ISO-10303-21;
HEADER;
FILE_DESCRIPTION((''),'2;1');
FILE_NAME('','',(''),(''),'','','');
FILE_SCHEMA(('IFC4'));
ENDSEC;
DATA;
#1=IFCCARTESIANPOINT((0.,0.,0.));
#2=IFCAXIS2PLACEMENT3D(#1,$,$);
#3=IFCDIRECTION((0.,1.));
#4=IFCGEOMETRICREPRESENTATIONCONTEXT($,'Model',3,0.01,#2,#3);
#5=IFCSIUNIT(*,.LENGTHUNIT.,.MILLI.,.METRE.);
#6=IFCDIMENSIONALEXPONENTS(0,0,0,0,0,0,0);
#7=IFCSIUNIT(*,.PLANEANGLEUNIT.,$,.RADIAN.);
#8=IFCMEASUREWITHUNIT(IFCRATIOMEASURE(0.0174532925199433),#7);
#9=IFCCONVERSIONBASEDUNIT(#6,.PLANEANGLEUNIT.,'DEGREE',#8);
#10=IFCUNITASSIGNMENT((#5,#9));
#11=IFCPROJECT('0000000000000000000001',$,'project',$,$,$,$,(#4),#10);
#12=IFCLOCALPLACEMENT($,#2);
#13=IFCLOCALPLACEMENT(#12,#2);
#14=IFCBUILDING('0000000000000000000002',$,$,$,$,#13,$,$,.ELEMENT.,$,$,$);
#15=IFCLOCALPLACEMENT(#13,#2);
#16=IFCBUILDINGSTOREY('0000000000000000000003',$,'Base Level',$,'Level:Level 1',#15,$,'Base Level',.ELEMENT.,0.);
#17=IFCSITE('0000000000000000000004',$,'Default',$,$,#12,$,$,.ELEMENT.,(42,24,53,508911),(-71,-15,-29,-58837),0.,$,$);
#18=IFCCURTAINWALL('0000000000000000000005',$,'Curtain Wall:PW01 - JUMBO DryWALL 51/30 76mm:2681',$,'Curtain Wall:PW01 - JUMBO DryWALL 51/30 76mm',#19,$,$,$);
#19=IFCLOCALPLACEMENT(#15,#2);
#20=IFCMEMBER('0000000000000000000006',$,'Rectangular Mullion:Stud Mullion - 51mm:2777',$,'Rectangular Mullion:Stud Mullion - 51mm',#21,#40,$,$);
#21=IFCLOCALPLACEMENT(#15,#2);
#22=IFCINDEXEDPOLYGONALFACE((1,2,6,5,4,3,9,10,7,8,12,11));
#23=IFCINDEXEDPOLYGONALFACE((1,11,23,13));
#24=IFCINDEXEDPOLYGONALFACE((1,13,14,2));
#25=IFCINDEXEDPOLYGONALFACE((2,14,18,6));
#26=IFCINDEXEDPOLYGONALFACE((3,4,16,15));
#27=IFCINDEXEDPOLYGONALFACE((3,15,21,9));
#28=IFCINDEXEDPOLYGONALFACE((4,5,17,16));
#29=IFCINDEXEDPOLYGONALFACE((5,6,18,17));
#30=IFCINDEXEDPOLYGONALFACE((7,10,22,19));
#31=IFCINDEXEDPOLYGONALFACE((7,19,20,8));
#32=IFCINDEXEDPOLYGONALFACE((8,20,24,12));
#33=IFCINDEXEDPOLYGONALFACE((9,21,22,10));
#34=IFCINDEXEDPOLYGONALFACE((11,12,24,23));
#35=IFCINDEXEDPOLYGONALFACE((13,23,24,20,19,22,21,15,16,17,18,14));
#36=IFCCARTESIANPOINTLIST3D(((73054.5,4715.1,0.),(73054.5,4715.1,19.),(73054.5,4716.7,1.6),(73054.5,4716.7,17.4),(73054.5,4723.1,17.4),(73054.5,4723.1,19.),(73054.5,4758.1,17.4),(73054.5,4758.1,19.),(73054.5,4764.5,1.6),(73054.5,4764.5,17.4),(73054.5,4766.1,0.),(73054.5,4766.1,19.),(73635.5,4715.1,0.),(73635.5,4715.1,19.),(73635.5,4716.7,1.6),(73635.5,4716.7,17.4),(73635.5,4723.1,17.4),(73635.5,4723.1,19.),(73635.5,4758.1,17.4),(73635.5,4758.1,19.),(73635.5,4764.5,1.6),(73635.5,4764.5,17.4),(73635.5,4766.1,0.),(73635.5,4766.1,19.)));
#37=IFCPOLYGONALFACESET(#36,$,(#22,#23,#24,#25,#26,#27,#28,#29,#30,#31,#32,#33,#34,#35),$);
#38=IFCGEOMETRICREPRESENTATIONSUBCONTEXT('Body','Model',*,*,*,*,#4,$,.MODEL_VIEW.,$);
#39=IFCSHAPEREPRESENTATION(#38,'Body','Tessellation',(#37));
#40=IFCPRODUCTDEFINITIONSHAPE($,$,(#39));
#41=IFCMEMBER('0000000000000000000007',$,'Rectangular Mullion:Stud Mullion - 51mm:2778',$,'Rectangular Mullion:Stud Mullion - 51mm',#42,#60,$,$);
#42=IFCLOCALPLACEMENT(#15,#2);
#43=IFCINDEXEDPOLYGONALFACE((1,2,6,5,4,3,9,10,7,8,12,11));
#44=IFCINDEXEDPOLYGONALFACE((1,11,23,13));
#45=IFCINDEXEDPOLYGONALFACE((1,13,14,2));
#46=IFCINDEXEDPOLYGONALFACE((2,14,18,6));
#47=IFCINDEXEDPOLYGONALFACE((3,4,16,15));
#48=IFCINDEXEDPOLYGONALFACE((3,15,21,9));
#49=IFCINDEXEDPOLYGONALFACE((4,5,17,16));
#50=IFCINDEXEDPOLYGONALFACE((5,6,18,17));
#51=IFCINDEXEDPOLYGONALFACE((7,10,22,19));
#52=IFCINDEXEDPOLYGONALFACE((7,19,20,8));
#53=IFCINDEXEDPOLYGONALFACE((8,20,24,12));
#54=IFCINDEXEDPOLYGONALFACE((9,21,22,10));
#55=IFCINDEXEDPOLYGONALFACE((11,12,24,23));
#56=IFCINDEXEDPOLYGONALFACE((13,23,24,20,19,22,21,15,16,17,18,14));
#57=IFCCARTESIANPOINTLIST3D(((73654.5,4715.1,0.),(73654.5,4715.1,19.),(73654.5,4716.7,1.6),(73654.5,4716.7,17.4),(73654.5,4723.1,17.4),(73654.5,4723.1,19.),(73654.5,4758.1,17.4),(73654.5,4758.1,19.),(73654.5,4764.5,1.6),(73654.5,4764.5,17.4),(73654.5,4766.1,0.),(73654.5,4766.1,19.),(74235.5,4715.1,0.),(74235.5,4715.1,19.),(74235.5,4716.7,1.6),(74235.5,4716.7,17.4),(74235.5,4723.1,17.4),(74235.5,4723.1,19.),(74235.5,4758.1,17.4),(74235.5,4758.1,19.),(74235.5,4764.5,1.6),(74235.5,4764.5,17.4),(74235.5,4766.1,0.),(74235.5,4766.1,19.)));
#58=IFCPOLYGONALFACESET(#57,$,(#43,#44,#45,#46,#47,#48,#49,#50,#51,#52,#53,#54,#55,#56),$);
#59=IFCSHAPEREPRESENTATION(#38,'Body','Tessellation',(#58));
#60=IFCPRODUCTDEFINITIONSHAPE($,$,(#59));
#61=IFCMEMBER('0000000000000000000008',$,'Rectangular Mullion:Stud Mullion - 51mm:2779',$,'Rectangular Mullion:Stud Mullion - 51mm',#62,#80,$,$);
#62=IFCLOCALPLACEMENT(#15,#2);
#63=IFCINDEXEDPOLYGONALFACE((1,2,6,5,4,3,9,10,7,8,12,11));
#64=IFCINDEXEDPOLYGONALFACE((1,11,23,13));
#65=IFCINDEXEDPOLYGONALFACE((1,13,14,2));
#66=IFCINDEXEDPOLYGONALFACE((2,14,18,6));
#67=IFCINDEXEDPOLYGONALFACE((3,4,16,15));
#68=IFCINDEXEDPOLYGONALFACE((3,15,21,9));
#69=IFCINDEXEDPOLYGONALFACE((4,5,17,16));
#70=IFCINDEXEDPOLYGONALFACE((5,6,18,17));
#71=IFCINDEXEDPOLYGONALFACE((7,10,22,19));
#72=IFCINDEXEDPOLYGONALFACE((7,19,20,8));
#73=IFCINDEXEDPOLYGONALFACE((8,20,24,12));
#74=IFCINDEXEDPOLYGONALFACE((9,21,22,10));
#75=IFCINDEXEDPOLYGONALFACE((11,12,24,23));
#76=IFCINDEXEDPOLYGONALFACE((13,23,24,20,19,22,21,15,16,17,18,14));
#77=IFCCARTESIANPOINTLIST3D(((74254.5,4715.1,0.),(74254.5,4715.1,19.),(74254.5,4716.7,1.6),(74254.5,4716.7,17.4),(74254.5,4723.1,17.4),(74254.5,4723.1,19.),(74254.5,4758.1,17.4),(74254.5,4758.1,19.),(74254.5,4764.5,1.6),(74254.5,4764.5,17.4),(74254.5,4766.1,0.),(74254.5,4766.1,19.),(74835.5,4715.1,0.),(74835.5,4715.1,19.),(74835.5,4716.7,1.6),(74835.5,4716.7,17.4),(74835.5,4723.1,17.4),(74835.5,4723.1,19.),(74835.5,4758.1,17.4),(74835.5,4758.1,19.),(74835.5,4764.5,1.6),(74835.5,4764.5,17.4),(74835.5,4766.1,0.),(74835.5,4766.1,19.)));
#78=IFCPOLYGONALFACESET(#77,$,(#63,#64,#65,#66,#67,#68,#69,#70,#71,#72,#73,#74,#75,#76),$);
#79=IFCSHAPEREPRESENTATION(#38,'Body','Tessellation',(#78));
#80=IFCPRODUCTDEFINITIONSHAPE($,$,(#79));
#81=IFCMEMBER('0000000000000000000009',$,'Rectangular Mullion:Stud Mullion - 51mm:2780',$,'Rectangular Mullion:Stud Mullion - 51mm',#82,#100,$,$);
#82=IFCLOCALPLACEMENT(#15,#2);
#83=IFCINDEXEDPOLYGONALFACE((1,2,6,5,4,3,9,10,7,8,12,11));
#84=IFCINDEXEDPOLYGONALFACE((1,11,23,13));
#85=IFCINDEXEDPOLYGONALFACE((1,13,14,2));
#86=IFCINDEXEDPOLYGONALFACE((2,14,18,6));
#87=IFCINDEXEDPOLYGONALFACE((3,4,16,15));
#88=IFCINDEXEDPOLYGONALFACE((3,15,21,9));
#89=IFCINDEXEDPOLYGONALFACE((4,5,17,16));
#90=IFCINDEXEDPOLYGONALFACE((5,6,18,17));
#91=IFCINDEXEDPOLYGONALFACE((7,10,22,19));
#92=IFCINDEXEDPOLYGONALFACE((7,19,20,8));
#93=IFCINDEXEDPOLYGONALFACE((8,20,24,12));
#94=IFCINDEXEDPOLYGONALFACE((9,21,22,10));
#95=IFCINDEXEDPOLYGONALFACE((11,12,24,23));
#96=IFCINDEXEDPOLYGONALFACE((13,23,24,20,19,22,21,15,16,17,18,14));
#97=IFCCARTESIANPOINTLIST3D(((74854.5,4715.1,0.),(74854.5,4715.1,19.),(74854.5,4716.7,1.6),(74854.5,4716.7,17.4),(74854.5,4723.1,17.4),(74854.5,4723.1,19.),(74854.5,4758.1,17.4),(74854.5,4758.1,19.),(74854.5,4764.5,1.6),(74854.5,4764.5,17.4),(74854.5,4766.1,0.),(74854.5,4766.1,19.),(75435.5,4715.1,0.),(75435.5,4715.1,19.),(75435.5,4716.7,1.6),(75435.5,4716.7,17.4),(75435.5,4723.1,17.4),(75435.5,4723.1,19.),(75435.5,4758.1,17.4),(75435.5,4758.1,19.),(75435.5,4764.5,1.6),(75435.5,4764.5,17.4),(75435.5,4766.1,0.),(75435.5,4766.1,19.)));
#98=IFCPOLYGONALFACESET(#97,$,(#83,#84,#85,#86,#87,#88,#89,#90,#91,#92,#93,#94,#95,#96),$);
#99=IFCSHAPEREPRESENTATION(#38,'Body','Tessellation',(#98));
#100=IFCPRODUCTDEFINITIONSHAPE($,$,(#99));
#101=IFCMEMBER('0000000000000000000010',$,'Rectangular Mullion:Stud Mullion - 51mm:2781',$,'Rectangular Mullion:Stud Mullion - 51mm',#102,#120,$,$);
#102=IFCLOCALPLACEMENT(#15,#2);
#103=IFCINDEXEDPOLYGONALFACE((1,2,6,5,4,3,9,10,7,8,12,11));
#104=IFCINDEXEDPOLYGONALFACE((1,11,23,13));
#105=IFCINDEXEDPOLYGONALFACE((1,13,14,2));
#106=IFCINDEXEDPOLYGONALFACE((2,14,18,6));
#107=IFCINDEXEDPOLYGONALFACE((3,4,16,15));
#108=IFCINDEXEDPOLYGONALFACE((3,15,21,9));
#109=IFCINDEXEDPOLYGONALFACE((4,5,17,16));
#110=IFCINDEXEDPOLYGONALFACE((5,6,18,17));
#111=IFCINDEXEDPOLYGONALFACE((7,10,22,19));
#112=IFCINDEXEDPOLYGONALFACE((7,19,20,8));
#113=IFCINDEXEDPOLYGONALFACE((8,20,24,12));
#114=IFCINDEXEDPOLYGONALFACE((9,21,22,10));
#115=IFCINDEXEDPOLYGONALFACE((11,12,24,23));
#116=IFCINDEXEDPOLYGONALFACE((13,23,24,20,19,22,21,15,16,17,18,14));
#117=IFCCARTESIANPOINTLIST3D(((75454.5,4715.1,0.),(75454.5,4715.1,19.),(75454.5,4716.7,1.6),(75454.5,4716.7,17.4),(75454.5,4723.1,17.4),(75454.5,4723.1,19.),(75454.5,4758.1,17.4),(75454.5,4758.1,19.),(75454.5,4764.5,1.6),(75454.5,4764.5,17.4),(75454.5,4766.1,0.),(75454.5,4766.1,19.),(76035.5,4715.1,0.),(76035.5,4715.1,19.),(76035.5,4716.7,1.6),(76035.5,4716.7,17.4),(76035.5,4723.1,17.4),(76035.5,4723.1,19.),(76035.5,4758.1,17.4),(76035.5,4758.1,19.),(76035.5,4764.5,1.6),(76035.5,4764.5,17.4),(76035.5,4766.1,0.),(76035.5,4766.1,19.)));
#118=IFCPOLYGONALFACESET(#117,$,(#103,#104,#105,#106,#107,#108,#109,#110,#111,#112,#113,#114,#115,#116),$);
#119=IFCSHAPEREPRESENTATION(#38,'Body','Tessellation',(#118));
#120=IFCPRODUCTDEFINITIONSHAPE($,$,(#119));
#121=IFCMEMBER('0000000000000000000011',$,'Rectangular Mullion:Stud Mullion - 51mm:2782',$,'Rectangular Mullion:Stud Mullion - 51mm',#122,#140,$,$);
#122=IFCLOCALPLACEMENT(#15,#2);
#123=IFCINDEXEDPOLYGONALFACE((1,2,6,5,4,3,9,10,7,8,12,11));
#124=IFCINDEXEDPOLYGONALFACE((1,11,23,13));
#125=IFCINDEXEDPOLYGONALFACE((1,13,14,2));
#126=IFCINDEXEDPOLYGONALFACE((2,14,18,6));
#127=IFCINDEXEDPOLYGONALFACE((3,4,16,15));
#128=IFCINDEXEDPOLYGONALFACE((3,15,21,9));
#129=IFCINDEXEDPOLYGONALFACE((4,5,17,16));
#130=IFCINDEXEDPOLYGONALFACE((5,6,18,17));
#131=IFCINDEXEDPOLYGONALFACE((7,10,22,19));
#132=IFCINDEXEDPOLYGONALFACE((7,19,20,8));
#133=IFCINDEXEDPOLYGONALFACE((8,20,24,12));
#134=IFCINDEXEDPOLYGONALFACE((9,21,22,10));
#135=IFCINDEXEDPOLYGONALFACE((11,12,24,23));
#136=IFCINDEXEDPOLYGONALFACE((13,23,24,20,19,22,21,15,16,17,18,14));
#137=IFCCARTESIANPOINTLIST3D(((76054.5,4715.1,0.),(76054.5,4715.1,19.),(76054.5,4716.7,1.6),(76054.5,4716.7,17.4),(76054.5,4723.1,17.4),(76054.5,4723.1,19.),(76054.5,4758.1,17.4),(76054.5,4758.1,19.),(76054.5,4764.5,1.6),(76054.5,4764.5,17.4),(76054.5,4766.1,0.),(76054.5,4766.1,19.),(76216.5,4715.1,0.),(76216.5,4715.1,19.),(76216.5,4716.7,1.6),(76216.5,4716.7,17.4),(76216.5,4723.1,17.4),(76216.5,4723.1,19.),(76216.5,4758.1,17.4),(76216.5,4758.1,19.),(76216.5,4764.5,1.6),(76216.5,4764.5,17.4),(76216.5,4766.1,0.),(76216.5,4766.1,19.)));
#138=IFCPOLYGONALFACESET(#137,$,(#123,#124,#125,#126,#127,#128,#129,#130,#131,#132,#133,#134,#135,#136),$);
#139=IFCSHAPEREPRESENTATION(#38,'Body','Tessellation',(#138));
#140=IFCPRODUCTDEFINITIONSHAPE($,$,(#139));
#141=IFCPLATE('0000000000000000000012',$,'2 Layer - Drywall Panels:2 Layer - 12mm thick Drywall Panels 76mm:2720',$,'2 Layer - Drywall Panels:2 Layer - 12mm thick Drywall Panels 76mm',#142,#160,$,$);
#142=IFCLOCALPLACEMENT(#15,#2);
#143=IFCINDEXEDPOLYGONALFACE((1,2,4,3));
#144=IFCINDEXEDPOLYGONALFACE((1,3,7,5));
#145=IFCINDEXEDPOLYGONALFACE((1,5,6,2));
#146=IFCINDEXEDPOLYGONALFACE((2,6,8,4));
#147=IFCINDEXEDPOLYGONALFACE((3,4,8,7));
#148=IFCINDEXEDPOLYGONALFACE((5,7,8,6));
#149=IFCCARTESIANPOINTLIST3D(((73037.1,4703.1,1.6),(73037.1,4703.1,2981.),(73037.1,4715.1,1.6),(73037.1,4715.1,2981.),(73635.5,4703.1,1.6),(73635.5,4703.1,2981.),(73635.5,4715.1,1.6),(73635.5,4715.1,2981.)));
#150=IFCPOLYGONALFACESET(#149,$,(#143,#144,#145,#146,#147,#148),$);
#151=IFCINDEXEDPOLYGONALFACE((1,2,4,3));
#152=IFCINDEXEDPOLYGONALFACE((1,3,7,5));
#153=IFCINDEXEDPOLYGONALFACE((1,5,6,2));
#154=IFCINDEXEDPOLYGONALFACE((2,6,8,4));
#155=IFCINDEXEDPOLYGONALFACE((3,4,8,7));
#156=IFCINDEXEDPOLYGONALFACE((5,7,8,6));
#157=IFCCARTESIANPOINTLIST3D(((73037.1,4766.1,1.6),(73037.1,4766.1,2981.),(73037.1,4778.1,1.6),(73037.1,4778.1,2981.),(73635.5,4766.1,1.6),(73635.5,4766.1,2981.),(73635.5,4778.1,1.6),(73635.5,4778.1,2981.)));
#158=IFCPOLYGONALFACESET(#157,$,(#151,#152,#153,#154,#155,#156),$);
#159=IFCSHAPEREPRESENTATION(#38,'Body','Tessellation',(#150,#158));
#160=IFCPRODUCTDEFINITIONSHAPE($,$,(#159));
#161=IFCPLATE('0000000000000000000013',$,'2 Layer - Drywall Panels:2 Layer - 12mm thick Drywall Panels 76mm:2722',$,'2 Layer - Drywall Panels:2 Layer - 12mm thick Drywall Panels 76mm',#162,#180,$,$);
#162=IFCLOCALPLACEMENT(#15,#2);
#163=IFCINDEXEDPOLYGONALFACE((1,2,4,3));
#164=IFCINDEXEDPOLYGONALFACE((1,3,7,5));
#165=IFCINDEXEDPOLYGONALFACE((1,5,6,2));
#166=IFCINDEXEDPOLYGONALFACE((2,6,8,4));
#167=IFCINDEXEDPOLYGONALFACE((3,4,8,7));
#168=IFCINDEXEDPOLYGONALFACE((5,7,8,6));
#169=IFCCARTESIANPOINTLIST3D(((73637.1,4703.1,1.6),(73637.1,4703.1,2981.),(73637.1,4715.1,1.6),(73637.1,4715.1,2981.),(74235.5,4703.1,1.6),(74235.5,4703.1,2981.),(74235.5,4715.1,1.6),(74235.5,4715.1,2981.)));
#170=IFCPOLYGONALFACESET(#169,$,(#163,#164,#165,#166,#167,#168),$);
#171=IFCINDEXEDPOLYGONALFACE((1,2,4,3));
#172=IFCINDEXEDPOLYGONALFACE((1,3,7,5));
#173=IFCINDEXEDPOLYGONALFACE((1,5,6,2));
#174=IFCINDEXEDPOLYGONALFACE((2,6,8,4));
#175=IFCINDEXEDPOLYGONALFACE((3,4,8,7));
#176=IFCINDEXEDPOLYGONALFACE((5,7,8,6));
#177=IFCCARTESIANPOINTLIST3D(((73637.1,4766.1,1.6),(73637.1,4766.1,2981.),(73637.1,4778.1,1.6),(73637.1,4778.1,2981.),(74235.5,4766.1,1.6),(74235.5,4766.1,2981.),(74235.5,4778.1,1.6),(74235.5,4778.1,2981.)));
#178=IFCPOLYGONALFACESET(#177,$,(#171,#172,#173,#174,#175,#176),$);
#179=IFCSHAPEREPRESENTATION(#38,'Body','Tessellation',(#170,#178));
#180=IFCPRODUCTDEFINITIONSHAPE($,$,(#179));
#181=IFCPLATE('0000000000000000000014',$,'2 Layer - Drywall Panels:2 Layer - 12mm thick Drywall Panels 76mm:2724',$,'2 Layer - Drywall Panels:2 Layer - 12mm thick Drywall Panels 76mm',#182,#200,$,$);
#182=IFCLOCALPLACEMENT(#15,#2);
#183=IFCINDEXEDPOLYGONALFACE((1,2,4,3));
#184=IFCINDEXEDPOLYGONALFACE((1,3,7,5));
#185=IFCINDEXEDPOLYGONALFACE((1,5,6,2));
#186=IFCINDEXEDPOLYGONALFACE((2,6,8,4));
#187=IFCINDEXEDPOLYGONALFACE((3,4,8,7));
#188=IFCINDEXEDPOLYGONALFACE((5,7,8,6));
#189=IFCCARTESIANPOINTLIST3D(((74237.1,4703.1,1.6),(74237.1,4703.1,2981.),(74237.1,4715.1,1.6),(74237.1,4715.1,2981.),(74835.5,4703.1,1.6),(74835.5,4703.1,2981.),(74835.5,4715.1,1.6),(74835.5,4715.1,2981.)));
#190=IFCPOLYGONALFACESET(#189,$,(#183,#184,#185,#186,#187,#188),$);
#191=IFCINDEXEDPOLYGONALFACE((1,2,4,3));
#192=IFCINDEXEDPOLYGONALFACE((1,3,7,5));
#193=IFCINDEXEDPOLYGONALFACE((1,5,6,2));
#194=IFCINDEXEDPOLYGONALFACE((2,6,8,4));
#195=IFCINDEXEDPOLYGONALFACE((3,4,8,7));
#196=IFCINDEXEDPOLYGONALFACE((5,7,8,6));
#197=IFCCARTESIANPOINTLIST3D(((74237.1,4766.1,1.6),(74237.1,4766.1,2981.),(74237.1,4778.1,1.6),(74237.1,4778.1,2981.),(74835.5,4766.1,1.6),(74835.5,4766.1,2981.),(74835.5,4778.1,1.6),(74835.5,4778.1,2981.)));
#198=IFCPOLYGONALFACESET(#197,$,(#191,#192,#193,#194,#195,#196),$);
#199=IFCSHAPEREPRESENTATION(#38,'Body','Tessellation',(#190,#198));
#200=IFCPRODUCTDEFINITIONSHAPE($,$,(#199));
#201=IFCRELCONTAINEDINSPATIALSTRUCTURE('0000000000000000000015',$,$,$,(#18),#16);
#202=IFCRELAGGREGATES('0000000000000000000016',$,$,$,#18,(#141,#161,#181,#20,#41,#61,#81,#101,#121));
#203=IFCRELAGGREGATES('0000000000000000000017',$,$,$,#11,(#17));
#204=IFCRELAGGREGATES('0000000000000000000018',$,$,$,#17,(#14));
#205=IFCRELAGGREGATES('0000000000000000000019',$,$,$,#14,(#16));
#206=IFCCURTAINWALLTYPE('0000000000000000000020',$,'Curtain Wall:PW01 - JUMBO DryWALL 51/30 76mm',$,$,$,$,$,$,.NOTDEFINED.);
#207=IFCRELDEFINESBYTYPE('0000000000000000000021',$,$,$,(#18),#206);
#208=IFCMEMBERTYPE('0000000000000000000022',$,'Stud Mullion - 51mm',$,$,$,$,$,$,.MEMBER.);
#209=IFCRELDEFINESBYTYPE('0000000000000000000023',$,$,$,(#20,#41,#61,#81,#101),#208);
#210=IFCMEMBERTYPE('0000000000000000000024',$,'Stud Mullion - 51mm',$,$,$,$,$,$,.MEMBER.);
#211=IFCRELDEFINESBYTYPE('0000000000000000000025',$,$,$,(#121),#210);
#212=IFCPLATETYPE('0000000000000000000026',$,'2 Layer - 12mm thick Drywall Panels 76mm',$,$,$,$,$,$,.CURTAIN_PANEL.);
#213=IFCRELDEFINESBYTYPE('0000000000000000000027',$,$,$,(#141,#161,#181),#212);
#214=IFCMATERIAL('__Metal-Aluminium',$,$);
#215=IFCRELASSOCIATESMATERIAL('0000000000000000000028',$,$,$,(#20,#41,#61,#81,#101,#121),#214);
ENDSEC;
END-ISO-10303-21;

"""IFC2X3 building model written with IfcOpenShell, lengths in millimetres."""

from ifc_helpers import new_model, entity, si_unit, converted_unit, direction, frame, frame_2d, origin, origin_2d_with_axis, place, context, subcontext, project, spatial, polyline, rectangle, outline, extrude, source, transform, mapped, material, type_object, type_shapes, element, aggregate, save


model = new_model("IFC2X3")

# Units and contexts
model_context = context("Model", 3, precision=0.01, world=origin(), true_north=direction((0.0, 1.0)))
body_context = subcontext(model_context, "Body", "Model", "MODEL_VIEW")
ifc_project = project(units=[si_unit("LENGTHUNIT", "METRE", prefix="MILLI"), converted_unit("PLANEANGLEUNIT", "DEGREE", entity("IfcRatioMeasure", 0.0174532925199433), si_unit("PLANEANGLEUNIT", "RADIAN"), dimensions=[0, 0, 0, 0, 0, 0, 0])], contexts=[model_context])

# Site, building, storey
site_placement = place(None, origin())
site = spatial("IfcSite", under=ifc_project, at=site_placement, Name="Default", CompositionType="ELEMENT", RefLatitude=(42, 24, 53, 508911), RefLongitude=(-71, -15, -29, -58837), RefElevation=0.0)
building_placement = place(site_placement, origin())
building = spatial("IfcBuilding", under=site, at=building_placement, CompositionType="ELEMENT")
storey_placement = place(building_placement, origin())
storey = spatial("IfcBuildingStorey", under=building, at=storey_placement, Name="Base Level", ObjectType="Level:Level 1", LongName="Base Level", CompositionType="ELEMENT", Elevation=0.0)

# Curtain wall, members, plates
curtain_wall_type = type_object("IfcCurtainWallType", Name="Curtain Wall:PW01 - JUMBO DryWALL 51/30 76mm", PredefinedType="NOTDEFINED")
curtain_wall_placement = place(building_placement, origin())
curtain_wall = element("IfcCurtainWall", 1, at=curtain_wall_placement, inside=storey, type_object=curtain_wall_type, Name="Curtain Wall:PW01 - JUMBO DryWALL 51/30 76mm:2681", ObjectType="Curtain Wall:PW01 - JUMBO DryWALL 51/30 76mm")
ifc_material = material(Name="__Metal-Aluminium")
member_type_1 = type_object("IfcMemberType", Name="Stud Mullion - 51mm", PredefinedType="MEMBER")
shared_shape_1 = source(origin(), body_context, "Body", "SweptSolid", [
    extrude(outline(polyline([(17.5, -6.6), (25.5, -6.6), (25.5, 12.4), (-25.5, 12.4), (-25.5, -6.6), (-17.5, -6.6), (-17.5, -5.0), (-23.9, -5.0), (-23.9, 10.8), (23.9, 10.8), (23.9, -5.0), (17.5, -5.0), (17.5, -6.6)])), frame((-12.4, 0.0, -581.0), z_axis=(0.0, 0.0, 1.0), x_axis=(0.0, -1.0, 0.0)), (0.0, 0.0, 1.0), 581.0),
])
type_shapes(member_type_1, [shared_shape_1])
member_1_placement = place(building_placement, frame((73054.5, 4740.6, 0.0), z_axis=(-1.0, 0.0, 0.0), x_axis=(0.0, 0.0, -1.0)))
member_1 = element("IfcMember", 2, at=member_1_placement, type_object=member_type_1, material=ifc_material, Name="Rectangular Mullion:Stud Mullion - 51mm:2777", ObjectType="Rectangular Mullion:Stud Mullion - 51mm", context=body_context, shape_type="MappedRepresentation", body=[
    mapped(shared_shape_1, transform((0.0, 0.0, 0.0), scale=1.0)),
])
member_2_placement = place(building_placement, frame((73654.5, 4740.6, 0.0), z_axis=(-1.0, 0.0, 0.0), x_axis=(0.0, 0.0, -1.0)))
member_2 = element("IfcMember", 3, at=member_2_placement, type_object=member_type_1, material=ifc_material, Name="Rectangular Mullion:Stud Mullion - 51mm:2778", ObjectType="Rectangular Mullion:Stud Mullion - 51mm", context=body_context, shape_type="MappedRepresentation", body=[
    mapped(shared_shape_1, transform((0.0, 0.0, 0.0), scale=1.0)),
])
member_3_placement = place(building_placement, frame((74254.5, 4740.6, 0.0), z_axis=(-1.0, 0.0, 0.0), x_axis=(0.0, 0.0, -1.0)))
member_3 = element("IfcMember", 4, at=member_3_placement, type_object=member_type_1, material=ifc_material, Name="Rectangular Mullion:Stud Mullion - 51mm:2779", ObjectType="Rectangular Mullion:Stud Mullion - 51mm", context=body_context, shape_type="MappedRepresentation", body=[
    mapped(shared_shape_1, transform((0.0, 0.0, 0.0), scale=1.0)),
])
member_4_placement = place(building_placement, frame((74854.5, 4740.6, 0.0), z_axis=(-1.0, 0.0, 0.0), x_axis=(0.0, 0.0, -1.0)))
member_4 = element("IfcMember", 5, at=member_4_placement, type_object=member_type_1, material=ifc_material, Name="Rectangular Mullion:Stud Mullion - 51mm:2780", ObjectType="Rectangular Mullion:Stud Mullion - 51mm", context=body_context, shape_type="MappedRepresentation", body=[
    mapped(shared_shape_1, transform((0.0, 0.0, 0.0), scale=1.0)),
])
member_5_placement = place(building_placement, frame((75454.5, 4740.6, 0.0), z_axis=(-1.0, 0.0, 0.0), x_axis=(0.0, 0.0, -1.0)))
member_5 = element("IfcMember", 6, at=member_5_placement, type_object=member_type_1, material=ifc_material, Name="Rectangular Mullion:Stud Mullion - 51mm:2781", ObjectType="Rectangular Mullion:Stud Mullion - 51mm", context=body_context, shape_type="MappedRepresentation", body=[
    mapped(shared_shape_1, transform((0.0, 0.0, 0.0), scale=1.0)),
])
member_type_2 = type_object("IfcMemberType", Name="Stud Mullion - 51mm", PredefinedType="MEMBER")
shared_shape_2 = source(origin(), body_context, "Body", "SweptSolid", [
    extrude(outline(polyline([(17.5, -6.6), (25.5, -6.6), (25.5, 12.4), (-25.5, 12.4), (-25.5, -6.6), (-17.5, -6.6), (-17.5, -5.0), (-23.9, -5.0), (-23.9, 10.8), (23.9, 10.8), (23.9, -5.0), (17.5, -5.0), (17.5, -6.6)])), frame((-12.4, 0.0, -162.0), z_axis=(0.0, 0.0, 1.0), x_axis=(0.0, -1.0, 0.0)), (0.0, 0.0, 1.0), 162.0),
])
type_shapes(member_type_2, [shared_shape_2])
member_6_placement = place(building_placement, frame((76054.5, 4740.6, 0.0), z_axis=(-1.0, 0.0, 0.0), x_axis=(0.0, 0.0, -1.0)))
member_6 = element("IfcMember", 7, at=member_6_placement, type_object=member_type_2, material=ifc_material, Name="Rectangular Mullion:Stud Mullion - 51mm:2782", ObjectType="Rectangular Mullion:Stud Mullion - 51mm", context=body_context, shape_type="MappedRepresentation", body=[
    mapped(shared_shape_2, transform((0.0, 0.0, 0.0), scale=1.0)),
])
plate_type_1 = type_object("IfcPlateType", Name="2 Layer - 12mm thick Drywall Panels 76mm", PredefinedType="CURTAIN_PANEL")
shared_shape_3 = source(origin(), body_context, "Body", "SweptSolid", [
    extrude(rectangle(XDim=598.4, YDim=12.0, at=origin_2d_with_axis()), frame((0.0, -31.5, 0.0), z_axis=(0.0, 0.0, 1.0), x_axis=(-1.0, 0.0, 0.0)), (0.0, 0.0, 1.0), 2979.4),
    extrude(rectangle(XDim=12.0, YDim=598.4, at=frame_2d((0.0, 0.0), x_axis=(1.0, 0.0))), frame((0.0, 31.5, 0.0), z_axis=(0.0, 0.0, 1.0), x_axis=(0.0, 1.0, 0.0)), (0.0, 0.0, 1.0), 2979.4),
])
type_shapes(plate_type_1, [shared_shape_3])
plate_1_placement = place(curtain_wall_placement, frame((73336.3, 4740.6, 1.6)))
plate_1 = element("IfcPlate", 8, at=plate_1_placement, type_object=plate_type_1, Name="2 Layer - Drywall Panels:2 Layer - 12mm thick Drywall Panels 76mm:2720", ObjectType="2 Layer - Drywall Panels:2 Layer - 12mm thick Drywall Panels 76mm", context=body_context, shape_type="MappedRepresentation", body=[
    mapped(shared_shape_3, transform((0.0, 0.0, 0.0), scale=1.0)),
])
plate_2_placement = place(curtain_wall_placement, frame((73936.3, 4740.6, 1.6)))
plate_2 = element("IfcPlate", 9, at=plate_2_placement, type_object=plate_type_1, Name="2 Layer - Drywall Panels:2 Layer - 12mm thick Drywall Panels 76mm:2722", ObjectType="2 Layer - Drywall Panels:2 Layer - 12mm thick Drywall Panels 76mm", context=body_context, shape_type="MappedRepresentation", body=[
    mapped(shared_shape_3, transform((0.0, 0.0, 0.0), scale=1.0)),
])
plate_3_placement = place(curtain_wall_placement, frame((74536.3, 4740.6, 1.6)))
plate_3 = element("IfcPlate", 10, at=plate_3_placement, type_object=plate_type_1, Name="2 Layer - Drywall Panels:2 Layer - 12mm thick Drywall Panels 76mm:2724", ObjectType="2 Layer - Drywall Panels:2 Layer - 12mm thick Drywall Panels 76mm", context=body_context, shape_type="MappedRepresentation", body=[
    mapped(shared_shape_3, transform((0.0, 0.0, 0.0), scale=1.0)),
])
aggregate(curtain_wall, [plate_1, plate_2, plate_3, member_1, member_2, member_3, member_4, member_5, member_6])

save(model, "model.ifc")
